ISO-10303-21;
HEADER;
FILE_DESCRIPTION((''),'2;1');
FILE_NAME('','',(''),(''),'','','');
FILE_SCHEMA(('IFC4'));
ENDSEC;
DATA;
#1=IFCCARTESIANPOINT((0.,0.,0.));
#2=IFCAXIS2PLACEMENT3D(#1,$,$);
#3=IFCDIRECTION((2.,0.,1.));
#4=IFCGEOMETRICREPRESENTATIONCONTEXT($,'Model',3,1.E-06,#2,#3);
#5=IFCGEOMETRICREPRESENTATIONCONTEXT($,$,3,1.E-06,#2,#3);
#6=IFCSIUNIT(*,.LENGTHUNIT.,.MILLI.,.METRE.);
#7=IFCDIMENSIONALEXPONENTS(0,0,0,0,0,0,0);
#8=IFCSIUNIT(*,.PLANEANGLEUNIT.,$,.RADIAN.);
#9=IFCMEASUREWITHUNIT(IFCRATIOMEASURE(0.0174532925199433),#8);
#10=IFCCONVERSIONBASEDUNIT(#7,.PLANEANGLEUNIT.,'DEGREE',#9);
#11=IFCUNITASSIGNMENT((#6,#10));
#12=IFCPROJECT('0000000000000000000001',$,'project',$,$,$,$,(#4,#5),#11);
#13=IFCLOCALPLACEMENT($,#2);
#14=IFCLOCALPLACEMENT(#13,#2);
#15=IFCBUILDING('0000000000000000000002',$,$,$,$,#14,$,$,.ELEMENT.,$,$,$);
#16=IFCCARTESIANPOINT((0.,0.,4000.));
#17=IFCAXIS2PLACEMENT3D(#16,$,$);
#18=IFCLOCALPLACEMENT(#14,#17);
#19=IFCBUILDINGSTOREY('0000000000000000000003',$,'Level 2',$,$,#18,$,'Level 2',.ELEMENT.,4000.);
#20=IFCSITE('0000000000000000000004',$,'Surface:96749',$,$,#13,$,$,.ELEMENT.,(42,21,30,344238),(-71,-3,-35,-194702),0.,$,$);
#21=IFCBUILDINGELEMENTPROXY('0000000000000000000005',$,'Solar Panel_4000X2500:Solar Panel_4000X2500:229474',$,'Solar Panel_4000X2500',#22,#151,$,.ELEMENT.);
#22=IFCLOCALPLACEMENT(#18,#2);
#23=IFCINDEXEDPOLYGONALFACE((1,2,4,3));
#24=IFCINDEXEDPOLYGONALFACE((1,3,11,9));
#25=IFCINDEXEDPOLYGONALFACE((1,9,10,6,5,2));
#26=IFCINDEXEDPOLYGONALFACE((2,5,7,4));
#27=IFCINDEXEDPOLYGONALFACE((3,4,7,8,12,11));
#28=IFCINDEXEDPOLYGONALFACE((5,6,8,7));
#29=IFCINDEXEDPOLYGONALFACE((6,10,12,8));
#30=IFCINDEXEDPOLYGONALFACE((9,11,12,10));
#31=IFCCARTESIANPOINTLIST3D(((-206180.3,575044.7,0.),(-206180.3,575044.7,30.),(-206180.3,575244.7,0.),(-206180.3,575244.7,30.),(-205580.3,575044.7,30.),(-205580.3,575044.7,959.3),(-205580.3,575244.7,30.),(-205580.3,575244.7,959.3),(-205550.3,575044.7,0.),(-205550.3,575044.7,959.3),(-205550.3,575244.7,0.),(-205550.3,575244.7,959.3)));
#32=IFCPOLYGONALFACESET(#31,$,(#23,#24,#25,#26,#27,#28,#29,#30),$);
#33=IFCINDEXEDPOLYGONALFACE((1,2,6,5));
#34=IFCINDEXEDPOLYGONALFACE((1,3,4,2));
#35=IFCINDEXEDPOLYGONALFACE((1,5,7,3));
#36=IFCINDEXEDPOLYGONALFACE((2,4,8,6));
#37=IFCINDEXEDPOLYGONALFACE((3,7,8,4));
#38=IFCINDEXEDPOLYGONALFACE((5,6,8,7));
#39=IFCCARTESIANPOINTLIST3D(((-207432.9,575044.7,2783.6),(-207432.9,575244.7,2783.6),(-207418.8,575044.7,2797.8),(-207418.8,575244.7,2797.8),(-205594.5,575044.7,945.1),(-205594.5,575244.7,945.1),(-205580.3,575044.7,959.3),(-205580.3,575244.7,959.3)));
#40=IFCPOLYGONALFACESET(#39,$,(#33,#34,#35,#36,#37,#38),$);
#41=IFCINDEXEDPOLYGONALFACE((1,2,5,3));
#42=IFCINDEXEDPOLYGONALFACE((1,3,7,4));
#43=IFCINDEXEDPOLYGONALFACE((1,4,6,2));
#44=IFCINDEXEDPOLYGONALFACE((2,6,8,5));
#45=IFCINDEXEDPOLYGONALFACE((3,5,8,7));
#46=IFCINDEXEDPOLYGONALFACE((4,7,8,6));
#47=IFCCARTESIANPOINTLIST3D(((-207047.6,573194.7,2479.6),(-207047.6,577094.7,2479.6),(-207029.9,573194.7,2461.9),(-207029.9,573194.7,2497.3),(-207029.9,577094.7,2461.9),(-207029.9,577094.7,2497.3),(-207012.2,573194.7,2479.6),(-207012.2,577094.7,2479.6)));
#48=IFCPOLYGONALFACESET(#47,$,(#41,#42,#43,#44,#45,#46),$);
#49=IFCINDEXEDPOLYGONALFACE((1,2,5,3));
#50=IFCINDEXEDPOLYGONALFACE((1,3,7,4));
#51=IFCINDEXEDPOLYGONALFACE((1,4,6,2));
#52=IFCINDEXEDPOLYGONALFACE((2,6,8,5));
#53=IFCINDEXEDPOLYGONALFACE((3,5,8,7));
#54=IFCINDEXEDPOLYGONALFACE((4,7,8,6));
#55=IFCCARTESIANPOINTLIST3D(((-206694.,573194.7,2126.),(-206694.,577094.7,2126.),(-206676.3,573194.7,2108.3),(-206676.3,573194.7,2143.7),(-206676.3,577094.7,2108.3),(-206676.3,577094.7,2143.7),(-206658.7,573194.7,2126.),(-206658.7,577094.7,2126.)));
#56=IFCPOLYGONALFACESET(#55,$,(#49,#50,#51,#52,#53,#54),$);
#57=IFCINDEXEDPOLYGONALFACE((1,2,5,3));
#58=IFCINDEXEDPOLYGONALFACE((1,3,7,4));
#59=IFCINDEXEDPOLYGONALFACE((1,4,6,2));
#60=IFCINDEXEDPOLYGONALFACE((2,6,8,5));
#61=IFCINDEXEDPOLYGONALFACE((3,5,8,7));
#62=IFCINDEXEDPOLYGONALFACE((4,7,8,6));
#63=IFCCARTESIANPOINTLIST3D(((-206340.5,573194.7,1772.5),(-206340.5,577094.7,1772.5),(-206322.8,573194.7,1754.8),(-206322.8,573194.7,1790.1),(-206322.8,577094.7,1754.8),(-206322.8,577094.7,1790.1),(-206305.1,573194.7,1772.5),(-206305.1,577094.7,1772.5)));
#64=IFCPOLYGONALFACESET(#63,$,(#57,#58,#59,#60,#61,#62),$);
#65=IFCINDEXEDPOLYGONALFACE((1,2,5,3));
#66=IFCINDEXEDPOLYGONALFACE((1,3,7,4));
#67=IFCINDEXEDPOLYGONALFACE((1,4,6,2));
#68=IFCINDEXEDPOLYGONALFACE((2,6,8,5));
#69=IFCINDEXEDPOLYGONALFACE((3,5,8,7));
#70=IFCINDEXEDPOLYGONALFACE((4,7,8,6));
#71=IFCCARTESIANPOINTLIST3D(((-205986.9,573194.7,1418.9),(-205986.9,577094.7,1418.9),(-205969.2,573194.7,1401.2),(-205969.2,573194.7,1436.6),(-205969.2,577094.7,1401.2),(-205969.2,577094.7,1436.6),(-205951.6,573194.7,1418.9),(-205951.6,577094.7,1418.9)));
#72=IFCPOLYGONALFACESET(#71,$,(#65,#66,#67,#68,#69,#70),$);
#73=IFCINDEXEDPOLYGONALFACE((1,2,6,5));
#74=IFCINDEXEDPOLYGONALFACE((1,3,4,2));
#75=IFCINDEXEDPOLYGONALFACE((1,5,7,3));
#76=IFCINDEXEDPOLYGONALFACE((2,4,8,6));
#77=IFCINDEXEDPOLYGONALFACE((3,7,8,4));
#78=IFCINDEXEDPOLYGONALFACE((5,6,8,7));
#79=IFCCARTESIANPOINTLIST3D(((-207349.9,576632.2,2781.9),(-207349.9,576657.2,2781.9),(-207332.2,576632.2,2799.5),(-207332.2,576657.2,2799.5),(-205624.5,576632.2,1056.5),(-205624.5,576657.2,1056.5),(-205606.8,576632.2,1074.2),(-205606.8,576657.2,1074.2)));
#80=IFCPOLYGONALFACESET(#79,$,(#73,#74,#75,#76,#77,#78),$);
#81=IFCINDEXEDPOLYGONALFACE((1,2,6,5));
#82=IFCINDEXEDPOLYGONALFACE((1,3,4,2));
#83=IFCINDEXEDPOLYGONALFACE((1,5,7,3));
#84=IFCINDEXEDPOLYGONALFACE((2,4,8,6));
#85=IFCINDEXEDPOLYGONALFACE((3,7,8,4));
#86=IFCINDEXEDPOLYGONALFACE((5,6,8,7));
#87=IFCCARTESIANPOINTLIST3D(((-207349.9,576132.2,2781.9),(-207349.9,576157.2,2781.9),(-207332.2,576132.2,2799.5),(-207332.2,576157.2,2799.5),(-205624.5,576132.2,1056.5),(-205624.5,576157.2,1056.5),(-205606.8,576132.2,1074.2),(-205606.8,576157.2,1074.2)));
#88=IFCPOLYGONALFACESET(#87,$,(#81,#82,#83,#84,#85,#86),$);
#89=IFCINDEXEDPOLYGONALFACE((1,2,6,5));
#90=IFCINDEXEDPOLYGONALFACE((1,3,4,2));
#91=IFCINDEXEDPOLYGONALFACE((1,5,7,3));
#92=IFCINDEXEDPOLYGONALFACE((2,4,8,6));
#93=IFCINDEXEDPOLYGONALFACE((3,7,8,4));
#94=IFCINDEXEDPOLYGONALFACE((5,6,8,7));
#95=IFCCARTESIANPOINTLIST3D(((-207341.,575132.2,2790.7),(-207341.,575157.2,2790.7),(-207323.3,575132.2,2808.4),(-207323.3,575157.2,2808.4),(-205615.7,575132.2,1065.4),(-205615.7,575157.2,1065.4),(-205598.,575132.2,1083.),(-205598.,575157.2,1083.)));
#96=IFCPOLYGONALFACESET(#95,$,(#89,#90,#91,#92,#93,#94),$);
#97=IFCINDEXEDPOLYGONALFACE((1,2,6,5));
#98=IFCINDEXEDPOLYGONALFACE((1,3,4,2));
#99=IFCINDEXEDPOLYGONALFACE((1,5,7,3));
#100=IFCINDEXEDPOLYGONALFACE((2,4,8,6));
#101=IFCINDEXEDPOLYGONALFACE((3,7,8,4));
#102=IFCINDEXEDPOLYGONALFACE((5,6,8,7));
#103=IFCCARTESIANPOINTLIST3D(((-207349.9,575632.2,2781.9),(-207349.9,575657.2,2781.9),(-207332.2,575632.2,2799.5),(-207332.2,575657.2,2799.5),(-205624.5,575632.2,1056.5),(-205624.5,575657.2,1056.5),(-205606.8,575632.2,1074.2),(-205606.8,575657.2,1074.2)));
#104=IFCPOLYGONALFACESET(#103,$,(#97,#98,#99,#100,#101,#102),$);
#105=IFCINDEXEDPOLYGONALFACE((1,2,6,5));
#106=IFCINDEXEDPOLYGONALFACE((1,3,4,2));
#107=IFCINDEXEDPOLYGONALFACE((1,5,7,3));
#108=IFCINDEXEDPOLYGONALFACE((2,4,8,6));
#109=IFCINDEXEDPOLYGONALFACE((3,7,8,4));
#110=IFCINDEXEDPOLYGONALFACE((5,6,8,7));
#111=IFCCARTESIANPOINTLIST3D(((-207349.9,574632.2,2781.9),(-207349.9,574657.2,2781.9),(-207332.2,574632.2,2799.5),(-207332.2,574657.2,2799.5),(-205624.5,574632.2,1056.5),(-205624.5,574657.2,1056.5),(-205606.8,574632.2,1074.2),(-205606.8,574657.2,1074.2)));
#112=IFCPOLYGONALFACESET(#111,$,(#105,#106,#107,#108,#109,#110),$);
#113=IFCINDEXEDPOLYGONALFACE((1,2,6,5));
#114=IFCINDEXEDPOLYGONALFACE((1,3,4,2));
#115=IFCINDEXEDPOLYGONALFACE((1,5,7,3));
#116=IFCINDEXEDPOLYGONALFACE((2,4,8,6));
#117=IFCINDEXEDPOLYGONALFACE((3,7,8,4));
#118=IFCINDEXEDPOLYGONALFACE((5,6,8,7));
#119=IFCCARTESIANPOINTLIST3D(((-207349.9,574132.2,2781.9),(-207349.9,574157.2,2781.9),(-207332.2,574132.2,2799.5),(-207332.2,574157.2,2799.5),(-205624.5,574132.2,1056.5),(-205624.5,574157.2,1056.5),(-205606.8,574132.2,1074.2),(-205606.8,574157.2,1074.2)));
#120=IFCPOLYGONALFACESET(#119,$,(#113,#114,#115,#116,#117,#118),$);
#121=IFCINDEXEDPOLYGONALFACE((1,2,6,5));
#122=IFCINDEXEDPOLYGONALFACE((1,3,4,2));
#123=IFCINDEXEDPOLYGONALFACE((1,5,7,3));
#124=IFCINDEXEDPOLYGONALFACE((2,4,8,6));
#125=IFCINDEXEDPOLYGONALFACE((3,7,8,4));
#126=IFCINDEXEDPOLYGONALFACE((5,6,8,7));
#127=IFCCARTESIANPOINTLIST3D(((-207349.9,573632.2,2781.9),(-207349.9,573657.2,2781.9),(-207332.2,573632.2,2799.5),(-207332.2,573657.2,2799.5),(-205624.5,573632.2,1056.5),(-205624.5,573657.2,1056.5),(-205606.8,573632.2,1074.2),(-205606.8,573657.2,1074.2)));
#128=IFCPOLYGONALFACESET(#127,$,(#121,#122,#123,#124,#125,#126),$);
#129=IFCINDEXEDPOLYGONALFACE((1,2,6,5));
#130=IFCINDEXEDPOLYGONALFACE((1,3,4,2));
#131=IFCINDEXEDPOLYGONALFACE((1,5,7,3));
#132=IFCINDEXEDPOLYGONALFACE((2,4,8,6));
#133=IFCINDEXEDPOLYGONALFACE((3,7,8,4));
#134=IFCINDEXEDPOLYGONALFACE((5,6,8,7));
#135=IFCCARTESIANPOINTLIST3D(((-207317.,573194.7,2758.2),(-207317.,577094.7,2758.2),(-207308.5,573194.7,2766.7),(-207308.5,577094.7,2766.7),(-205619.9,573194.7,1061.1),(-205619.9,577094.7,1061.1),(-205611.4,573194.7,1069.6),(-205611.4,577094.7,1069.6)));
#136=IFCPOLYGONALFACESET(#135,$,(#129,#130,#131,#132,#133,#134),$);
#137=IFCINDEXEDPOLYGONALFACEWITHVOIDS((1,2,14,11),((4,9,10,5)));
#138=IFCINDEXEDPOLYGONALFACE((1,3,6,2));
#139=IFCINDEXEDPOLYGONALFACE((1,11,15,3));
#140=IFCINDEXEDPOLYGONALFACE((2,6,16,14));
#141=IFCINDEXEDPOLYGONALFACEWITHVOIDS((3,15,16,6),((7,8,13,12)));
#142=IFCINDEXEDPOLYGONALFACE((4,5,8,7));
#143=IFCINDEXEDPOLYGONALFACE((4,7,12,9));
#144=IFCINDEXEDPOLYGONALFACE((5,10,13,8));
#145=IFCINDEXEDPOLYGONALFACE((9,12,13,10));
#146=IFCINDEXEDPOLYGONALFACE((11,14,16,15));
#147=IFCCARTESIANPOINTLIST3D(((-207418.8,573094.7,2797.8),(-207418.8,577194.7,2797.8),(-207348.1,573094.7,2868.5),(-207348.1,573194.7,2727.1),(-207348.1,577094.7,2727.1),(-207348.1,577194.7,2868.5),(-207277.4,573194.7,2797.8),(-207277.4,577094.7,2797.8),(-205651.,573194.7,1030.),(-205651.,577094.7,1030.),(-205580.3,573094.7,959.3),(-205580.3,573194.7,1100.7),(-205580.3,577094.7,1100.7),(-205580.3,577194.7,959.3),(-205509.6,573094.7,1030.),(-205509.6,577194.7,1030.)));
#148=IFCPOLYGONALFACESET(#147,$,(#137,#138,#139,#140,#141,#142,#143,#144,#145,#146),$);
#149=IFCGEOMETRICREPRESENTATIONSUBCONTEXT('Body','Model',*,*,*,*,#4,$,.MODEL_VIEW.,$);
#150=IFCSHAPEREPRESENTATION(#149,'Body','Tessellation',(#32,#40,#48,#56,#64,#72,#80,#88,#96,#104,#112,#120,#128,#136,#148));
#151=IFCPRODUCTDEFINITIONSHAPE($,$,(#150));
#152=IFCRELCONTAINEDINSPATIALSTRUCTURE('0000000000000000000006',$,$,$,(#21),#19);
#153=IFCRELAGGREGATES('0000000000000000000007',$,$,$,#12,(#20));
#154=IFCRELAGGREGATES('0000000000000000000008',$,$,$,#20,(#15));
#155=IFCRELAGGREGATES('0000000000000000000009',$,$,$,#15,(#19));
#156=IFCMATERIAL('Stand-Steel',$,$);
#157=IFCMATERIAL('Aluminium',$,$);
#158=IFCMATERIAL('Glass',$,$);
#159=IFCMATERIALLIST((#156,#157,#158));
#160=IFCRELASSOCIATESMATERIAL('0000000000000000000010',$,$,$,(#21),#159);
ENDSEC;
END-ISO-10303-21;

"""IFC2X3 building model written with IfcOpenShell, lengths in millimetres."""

from ifc_helpers import new_model, entity, si_unit, converted_unit, direction, frame, frame_2d, origin, origin_2d_with_axis, place, context, subcontext, project, spatial, polyline, rectangle, outline, extrude, source, transform, mapped, material, material_list, element, save


model = new_model("IFC2X3")

# Units and contexts
model_context = context("Model", 3, precision=1e-06, world=origin(), true_north=direction((2.0, 0.0, 1.0)))
context_of_model = context(None, 3, precision=1e-06, world=origin(), true_north=direction((2.0, 0.0, 1.0)))
body_context = subcontext(model_context, "Body", "Model", "MODEL_VIEW")
ifc_project = project(units=[si_unit("LENGTHUNIT", "METRE", prefix="MILLI"), converted_unit("PLANEANGLEUNIT", "DEGREE", entity("IfcRatioMeasure", 0.0174532925199433), si_unit("PLANEANGLEUNIT", "RADIAN"), dimensions=[0, 0, 0, 0, 0, 0, 0])], contexts=[model_context, context_of_model])

# Site, building, storey
site_placement = place(None, origin())
site = spatial("IfcSite", under=ifc_project, at=site_placement, Name="Surface:96749", CompositionType="ELEMENT", RefLatitude=(42, 21, 30, 344238), RefLongitude=(-71, -3, -35, -194702), RefElevation=0.0)
building_placement = place(site_placement, origin())
building = spatial("IfcBuilding", under=site, at=building_placement, CompositionType="ELEMENT")
storey_placement = place(building_placement, frame((0.0, 0.0, 4000.0)))
storey = spatial("IfcBuildingStorey", under=building, at=storey_placement, Name="Level 2", LongName="Level 2", CompositionType="ELEMENT", Elevation=4000.0)

# Building element proxy
ifc_material_1 = material(Name="Stand-Steel")
ifc_material_2 = material(Name="Aluminium")
ifc_material_3 = material(Name="Glass")
shared_shape = source(origin(), body_context, "Body", "SweptSolid", [
    extrude(outline(polyline([(-629.5, -220.0), (329.8, -220.0), (329.8, 410.0), (299.8, 410.0), (299.8, -190.0), (-629.5, -190.0), (-629.5, -220.0)])), frame((-190.0, -100.0, 299.8), z_axis=(0.0, 1.0, 0.0), x_axis=(0.0, 0.0, -1.0)), (0.0, 0.0, 1.0), 200.0),
    extrude(rectangle(XDim=20.0, YDim=200.0, at=frame_2d((0.0, 0.0), x_axis=(0.0, 1.0))), frame((-7.1, 0.0, 922.2), z_axis=(-0.707107, 0.0, 0.707107), x_axis=(0.0, 1.0, 0.0)), (0.0, 0.0, 1.0), 2600.0),
    extrude(rectangle(XDim=25.0, YDim=25.0, at=frame_2d((0.0, 0.0), x_axis=(1.0, 0.0))), frame((-1449.6, -1950.0, 2449.6), z_axis=(0.0, 1.0, 0.0), x_axis=(-0.707107, 0.0, -0.707107)), (0.0, 0.0, 1.0), 3900.0),
    extrude(rectangle(XDim=25.0, YDim=25.0, at=origin_2d_with_axis()), frame((-1096.0, -1950.0, 2096.0), z_axis=(0.0, 1.0, 0.0), x_axis=(-0.707107, 0.0, -0.707107)), (0.0, 0.0, 1.0), 3900.0),
    extrude(rectangle(XDim=25.0, YDim=25.0, at=origin_2d_with_axis()), frame((-742.5, -1950.0, 1742.5), z_axis=(0.0, 1.0, 0.0), x_axis=(-0.707107, 0.0, -0.707107)), (0.0, 0.0, 1.0), 3900.0),
    extrude(rectangle(XDim=25.0, YDim=25.0, at=frame_2d((0.0, 0.0), x_axis=(1.0, 0.0))), frame((-388.9, -1950.0, 1388.9), z_axis=(0.0, 1.0, 0.0), x_axis=(-0.707107, 0.0, -0.707107)), (0.0, 0.0, 1.0), 3900.0),
    extrude(rectangle(XDim=25.0, YDim=25.0, at=frame_2d((0.0, 0.0), x_axis=(0.0, 1.0))), frame((-35.4, 1500.0, 1035.4), z_axis=(-0.707107, 0.0, 0.707107), x_axis=(0.0, 1.0, 0.0)), (0.0, 0.0, 1.0), 2440.0),
    extrude(rectangle(XDim=25.0, YDim=25.0, at=frame_2d((0.0, 0.0), x_axis=(0.0, 1.0))), frame((-35.4, 1000.0, 1035.4), z_axis=(-0.707107, 0.0, 0.707107), x_axis=(0.0, 1.0, 0.0)), (0.0, 0.0, 1.0), 2440.0),
    extrude(rectangle(XDim=25.0, YDim=25.0, at=frame_2d((0.0, 0.0), x_axis=(0.0, 1.0))), frame((-26.5, 0.0, 1044.2), z_axis=(-0.707107, 0.0, 0.707107), x_axis=(0.0, -1.0, 0.0)), (0.0, 0.0, 1.0), 2440.0),
    extrude(rectangle(XDim=25.0, YDim=25.0, at=frame_2d((0.0, 0.0), x_axis=(0.0, 1.0))), frame((-35.4, 500.0, 1035.4), z_axis=(-0.707107, 0.0, 0.707107), x_axis=(0.0, 1.0, 0.0)), (0.0, 0.0, 1.0), 2440.0),
    extrude(rectangle(XDim=25.0, YDim=25.0, at=frame_2d((0.0, 0.0), x_axis=(0.0, 1.0))), frame((-35.4, -500.0, 1035.4), z_axis=(-0.707107, 0.0, 0.707107), x_axis=(0.0, 1.0, 0.0)), (0.0, 0.0, 1.0), 2440.0),
    extrude(rectangle(XDim=25.0, YDim=25.0, at=frame_2d((0.0, 0.0), x_axis=(0.0, 1.0))), frame((-35.4, -1000.0, 1035.4), z_axis=(-0.707107, 0.0, 0.707107), x_axis=(0.0, 1.0, 0.0)), (0.0, 0.0, 1.0), 2440.0),
    extrude(rectangle(XDim=25.0, YDim=25.0, at=frame_2d((0.0, 0.0), x_axis=(0.0, 1.0))), frame((-35.4, -1500.0, 1035.4), z_axis=(-0.707107, 0.0, 0.707107), x_axis=(0.0, 1.0, 0.0)), (0.0, 0.0, 1.0), 2440.0),
    extrude(rectangle(XDim=2400.0, YDim=12.0, at=frame_2d((0.0, 0.0), x_axis=(1.0, 0.0))), frame((-883.9, -1950.0, 1883.9), z_axis=(0.0, 1.0, 0.0), x_axis=(0.707107, 0.0, -0.707107)), (0.0, 0.0, 1.0), 3900.0),
    extrude(outline(polyline([(-2050.0, -1300.0), (2050.0, -1300.0), (2050.0, 1300.0), (-2050.0, 1300.0), (-2050.0, -1300.0)]), holes=[polyline([(1950.0, -1200.0), (-1950.0, -1200.0), (-1950.0, 1200.0), (1950.0, 1200.0), (1950.0, -1200.0)])]), frame((-919.2, 0.0, 1848.5), z_axis=(0.707107, 0.0, 0.707107), x_axis=(0.0, 1.0, 0.0)), (0.0, 0.0, 1.0), 100.0),
])
ifc_material_list_1 = material_list([ifc_material_1, ifc_material_2, ifc_material_3])
proxy_1_placement = place(storey_placement, frame((-205580.3, 575144.7, 30.0)))
element("IfcBuildingElementProxy", 1, at=proxy_1_placement, inside=storey, material=ifc_material_list_1, Name="Solar Panel_4000X2500:Solar Panel_4000X2500:229474", ObjectType="Solar Panel_4000X2500", CompositionType="ELEMENT", context=body_context, shape_type="MappedRepresentation", body=[
    mapped(shared_shape, transform((0.0, 0.0, 0.0), scale=1.0)),
])

save(model, "model.ifc")
